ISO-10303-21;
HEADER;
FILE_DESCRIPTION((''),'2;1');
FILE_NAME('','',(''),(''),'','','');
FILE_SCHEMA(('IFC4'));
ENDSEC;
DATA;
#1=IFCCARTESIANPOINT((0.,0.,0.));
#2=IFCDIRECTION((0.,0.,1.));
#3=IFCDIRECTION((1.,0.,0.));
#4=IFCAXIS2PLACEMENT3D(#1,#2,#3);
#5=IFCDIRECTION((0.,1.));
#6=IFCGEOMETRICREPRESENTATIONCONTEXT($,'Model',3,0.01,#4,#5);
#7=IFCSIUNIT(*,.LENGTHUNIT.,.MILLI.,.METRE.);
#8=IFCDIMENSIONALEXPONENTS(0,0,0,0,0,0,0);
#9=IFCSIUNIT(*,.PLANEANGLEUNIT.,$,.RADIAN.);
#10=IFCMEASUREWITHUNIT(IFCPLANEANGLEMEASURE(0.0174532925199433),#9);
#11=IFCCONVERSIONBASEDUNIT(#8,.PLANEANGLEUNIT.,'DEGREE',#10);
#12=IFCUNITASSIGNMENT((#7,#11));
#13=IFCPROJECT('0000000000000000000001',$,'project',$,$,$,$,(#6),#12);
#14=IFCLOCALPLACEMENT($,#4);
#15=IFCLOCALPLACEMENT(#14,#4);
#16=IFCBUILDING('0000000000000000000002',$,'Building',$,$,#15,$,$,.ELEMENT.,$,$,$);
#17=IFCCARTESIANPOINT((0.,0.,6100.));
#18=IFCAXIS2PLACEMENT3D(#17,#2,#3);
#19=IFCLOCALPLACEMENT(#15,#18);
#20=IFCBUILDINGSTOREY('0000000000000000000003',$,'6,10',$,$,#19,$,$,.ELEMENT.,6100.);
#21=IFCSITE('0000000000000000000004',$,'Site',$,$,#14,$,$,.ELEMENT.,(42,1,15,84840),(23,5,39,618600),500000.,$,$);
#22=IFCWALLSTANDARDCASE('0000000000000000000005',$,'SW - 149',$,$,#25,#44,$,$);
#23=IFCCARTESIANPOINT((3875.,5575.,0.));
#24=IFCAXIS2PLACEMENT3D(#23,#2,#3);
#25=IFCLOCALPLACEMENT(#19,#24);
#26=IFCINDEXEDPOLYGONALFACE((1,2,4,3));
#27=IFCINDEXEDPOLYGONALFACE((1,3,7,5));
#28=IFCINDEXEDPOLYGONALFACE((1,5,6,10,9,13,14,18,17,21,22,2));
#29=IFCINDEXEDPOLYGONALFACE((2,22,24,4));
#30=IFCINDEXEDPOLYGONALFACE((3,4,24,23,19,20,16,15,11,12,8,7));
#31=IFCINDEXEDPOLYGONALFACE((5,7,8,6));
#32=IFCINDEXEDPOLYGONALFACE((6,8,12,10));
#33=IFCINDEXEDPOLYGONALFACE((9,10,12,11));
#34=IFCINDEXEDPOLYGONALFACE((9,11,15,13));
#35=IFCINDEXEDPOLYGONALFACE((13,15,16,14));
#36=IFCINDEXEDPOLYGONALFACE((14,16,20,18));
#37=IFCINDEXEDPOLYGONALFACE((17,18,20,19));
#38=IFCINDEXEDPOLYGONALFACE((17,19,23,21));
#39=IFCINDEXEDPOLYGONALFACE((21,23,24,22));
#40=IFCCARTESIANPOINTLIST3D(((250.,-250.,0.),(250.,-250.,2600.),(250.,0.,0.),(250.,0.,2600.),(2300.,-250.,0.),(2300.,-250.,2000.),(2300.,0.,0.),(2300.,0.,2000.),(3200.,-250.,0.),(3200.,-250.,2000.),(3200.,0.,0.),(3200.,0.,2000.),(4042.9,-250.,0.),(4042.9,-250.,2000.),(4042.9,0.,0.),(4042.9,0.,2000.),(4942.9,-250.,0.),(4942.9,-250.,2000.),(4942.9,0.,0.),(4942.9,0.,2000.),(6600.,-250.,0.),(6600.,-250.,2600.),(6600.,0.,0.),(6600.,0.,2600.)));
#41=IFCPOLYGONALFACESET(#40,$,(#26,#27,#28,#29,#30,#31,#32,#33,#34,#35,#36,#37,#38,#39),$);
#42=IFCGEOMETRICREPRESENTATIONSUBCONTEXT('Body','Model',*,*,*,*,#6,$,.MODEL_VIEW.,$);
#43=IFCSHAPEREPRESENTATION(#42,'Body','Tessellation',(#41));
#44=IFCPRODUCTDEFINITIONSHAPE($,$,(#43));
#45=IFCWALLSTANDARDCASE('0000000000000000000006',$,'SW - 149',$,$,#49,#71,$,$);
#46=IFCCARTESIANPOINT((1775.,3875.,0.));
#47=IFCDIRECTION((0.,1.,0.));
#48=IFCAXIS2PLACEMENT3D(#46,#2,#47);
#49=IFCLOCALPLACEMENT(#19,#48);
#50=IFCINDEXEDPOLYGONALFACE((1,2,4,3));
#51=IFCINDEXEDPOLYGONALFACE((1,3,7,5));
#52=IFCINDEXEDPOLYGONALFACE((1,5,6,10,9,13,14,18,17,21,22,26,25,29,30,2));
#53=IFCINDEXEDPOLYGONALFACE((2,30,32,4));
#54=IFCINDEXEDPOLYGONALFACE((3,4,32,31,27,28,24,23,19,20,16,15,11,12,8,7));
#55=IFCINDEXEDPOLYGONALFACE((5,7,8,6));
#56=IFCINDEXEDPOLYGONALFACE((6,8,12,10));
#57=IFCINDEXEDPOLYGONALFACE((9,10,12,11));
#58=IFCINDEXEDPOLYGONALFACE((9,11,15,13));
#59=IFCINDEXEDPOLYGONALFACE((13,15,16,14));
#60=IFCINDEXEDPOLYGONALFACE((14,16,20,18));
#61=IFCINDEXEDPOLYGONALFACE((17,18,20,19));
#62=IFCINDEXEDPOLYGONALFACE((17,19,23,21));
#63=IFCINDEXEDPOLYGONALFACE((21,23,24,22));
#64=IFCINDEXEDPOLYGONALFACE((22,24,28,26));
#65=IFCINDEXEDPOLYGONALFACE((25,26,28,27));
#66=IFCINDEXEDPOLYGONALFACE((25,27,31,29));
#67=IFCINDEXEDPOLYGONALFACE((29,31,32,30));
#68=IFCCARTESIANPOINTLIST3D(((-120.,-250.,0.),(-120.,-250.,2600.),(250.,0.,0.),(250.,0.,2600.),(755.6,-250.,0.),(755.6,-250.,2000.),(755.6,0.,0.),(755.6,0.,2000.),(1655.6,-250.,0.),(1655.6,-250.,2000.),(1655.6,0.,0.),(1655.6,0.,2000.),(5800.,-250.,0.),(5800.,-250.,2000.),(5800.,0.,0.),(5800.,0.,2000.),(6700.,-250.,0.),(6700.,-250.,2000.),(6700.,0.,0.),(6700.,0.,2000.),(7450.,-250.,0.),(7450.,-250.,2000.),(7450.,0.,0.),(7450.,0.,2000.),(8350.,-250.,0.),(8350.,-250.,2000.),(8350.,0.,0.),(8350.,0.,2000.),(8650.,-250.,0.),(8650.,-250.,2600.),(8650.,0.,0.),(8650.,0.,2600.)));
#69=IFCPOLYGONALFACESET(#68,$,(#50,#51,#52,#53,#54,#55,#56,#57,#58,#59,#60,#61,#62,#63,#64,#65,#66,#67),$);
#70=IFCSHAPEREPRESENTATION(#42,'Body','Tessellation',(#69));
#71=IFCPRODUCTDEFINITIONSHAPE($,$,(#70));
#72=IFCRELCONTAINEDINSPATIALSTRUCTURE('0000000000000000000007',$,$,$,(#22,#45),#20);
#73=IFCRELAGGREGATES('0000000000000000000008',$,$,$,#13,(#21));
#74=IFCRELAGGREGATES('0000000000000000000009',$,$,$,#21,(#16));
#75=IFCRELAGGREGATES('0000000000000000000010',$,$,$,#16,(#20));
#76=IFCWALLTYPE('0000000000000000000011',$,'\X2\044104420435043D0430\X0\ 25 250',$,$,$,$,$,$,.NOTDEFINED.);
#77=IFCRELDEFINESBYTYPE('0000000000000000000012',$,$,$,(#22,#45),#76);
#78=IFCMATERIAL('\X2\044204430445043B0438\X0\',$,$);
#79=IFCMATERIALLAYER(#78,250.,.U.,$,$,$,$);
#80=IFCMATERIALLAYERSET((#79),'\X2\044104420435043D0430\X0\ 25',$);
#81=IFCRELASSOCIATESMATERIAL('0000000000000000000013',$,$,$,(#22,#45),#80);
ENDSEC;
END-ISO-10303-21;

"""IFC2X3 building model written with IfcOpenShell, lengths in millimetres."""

from ifc_helpers import new_model, entity, si_unit, converted_unit, direction, frame, origin_with_axes, origin_2d_with_axis, place, context, subcontext, project, spatial, polyline, rectangle, outline, extrude, material, layer, layer_set, layer_usage, type_object, element, save


model = new_model("IFC2X3")

# Units and contexts
model_context = context("Model", 3, precision=0.01, world=origin_with_axes(), true_north=direction((0.0, 1.0)))
body_context = subcontext(model_context, "Body", "Model", "MODEL_VIEW")
ifc_project = project(units=[si_unit("LENGTHUNIT", "METRE", prefix="MILLI"), converted_unit("PLANEANGLEUNIT", "DEGREE", entity("IfcPlaneAngleMeasure", 0.0174532925199433), si_unit("PLANEANGLEUNIT", "RADIAN"), dimensions=[0, 0, 0, 0, 0, 0, 0])], contexts=[model_context])

# Site, building, storey
site_placement = place(None, origin_with_axes())
site = spatial("IfcSite", under=ifc_project, at=site_placement, Name="Site", CompositionType="ELEMENT", RefLatitude=(42, 1, 15, 84840), RefLongitude=(23, 5, 39, 618600), RefElevation=500000.0)
building_placement = place(site_placement, origin_with_axes())
building = spatial("IfcBuilding", under=site, at=building_placement, Name="Building", CompositionType="ELEMENT")
storey_placement = place(building_placement, frame((0.0, 0.0, 6100.0), z_axis=(0.0, 0.0, 1.0), x_axis=(1.0, 0.0, 0.0)))
storey = spatial("IfcBuildingStorey", under=building, at=storey_placement, Name="6,10", CompositionType="ELEMENT", Elevation=6100.0)

# Shared definitions
ifc_material_1 = material(Name="тухли")

# Shared definitions
ifc_layer_1 = layer(ifc_material_1, 250.0, ventilated="UNKNOWN")
ifc_layer_set_1 = layer_set([ifc_layer_1], Name="стена 25")
wall_type_1 = type_object("IfcWallType", Name="стена 25 250", PredefinedType="NOTDEFINED")

# Walls, openings
ifc_layer_usage_1 = layer_usage(ifc_layer_set_1, "AXIS2", "NEGATIVE", 0.0)
wall_1_placement = place(storey_placement, frame((3875.0, 5575.0, 0.0), z_axis=(0.0, 0.0, 1.0), x_axis=(1.0, 0.0, 0.0)))
wall_1 = element("IfcWallStandardCase", 1, at=wall_1_placement, inside=storey, type_object=wall_type_1, material=ifc_layer_usage_1, Name="SW - 149", context=body_context, shape_type="SweptSolid", body=[
    extrude(outline(polyline([(250.0, -250.0), (6600.0, -250.0), (6600.0, 0.0), (250.0, 0.0), (250.0, -250.0)])), origin_with_axes(), (0.0, 0.0, 1.0), 2600.0),
])
opening_1_placement = place(wall_1_placement, frame((4492.9, 0.0, 0.0), z_axis=(0.0, 0.0, 1.0), x_axis=(1.0, 0.0, 0.0)))
element("IfcOpeningElement", 2, at=opening_1_placement, cuts=wall_1, context=body_context, shape_type="SweptSolid", body=[
    extrude(rectangle(XDim=900.0, YDim=2000.0, at=origin_2d_with_axis()), frame((0.0, 250.0, 1000.0), z_axis=(0.0, -1.0, 0.0), x_axis=(-1.0, 0.0, 0.0)), (0.0, 0.0, 1.0), 750.0),
])
opening_2_placement = place(wall_1_placement, frame((2750.0, 0.0, 0.0), z_axis=(0.0, 0.0, 1.0), x_axis=(1.0, 0.0, 0.0)))
element("IfcOpeningElement", 3, at=opening_2_placement, cuts=wall_1, context=body_context, shape_type="SweptSolid", body=[
    extrude(rectangle(XDim=900.0, YDim=2000.0, at=origin_2d_with_axis()), frame((0.0, 250.0, 1000.0), z_axis=(0.0, 1.0, 0.0), x_axis=(1.0, 0.0, 0.0)), (0.0, 0.0, -1.0), 750.0),
])
ifc_layer_usage_2 = layer_usage(ifc_layer_set_1, "AXIS2", "NEGATIVE", 0.0)
wall_2_placement = place(storey_placement, frame((1775.0, 3875.0, 0.0), z_axis=(0.0, 0.0, 1.0), x_axis=(0.0, 1.0, 0.0)))
wall_2 = element("IfcWallStandardCase", 4, at=wall_2_placement, inside=storey, type_object=wall_type_1, material=ifc_layer_usage_2, Name="SW - 149", context=body_context, shape_type="SweptSolid", body=[
    extrude(outline(polyline([(-120.0, -250.0), (8650.0, -250.0), (8650.0, 0.0), (250.0, 0.0), (-120.0, -250.0)])), origin_with_axes(), (0.0, 0.0, 1.0), 2600.0),
])
opening_3_placement = place(wall_2_placement, frame((7900.0, 0.0, 0.0), z_axis=(0.0, 0.0, 1.0), x_axis=(1.0, 0.0, 0.0)))
element("IfcOpeningElement", 5, at=opening_3_placement, cuts=wall_2, context=body_context, shape_type="SweptSolid", body=[
    extrude(rectangle(XDim=900.0, YDim=2000.0, at=origin_2d_with_axis()), frame((0.0, -250.0, 1000.0), z_axis=(0.0, -1.0, 0.0), x_axis=(-1.0, 0.0, 0.0)), (0.0, 0.0, -1.0), 750.0),
])
opening_4_placement = place(wall_2_placement, frame((1205.6, 0.0, 0.0), z_axis=(0.0, 0.0, 1.0), x_axis=(1.0, 0.0, 0.0)))
element("IfcOpeningElement", 6, at=opening_4_placement, cuts=wall_2, context=body_context, shape_type="SweptSolid", body=[
    extrude(rectangle(XDim=900.0, YDim=2000.0, at=origin_2d_with_axis()), frame((0.0, -250.0, 1000.0), z_axis=(0.0, -1.0, 0.0), x_axis=(-1.0, 0.0, 0.0)), (0.0, 0.0, -1.0), 750.0),
])
opening_5_placement = place(wall_2_placement, frame((6250.0, 0.0, 0.0), z_axis=(0.0, 0.0, 1.0), x_axis=(1.0, 0.0, 0.0)))
element("IfcOpeningElement", 7, at=opening_5_placement, cuts=wall_2, context=body_context, shape_type="SweptSolid", body=[
    extrude(rectangle(XDim=900.0, YDim=2000.0, at=origin_2d_with_axis()), frame((0.0, -250.0, 1000.0), z_axis=(0.0, 1.0, 0.0), x_axis=(1.0, 0.0, 0.0)), (0.0, 0.0, 1.0), 750.0),
])

save(model, "model.ifc")
